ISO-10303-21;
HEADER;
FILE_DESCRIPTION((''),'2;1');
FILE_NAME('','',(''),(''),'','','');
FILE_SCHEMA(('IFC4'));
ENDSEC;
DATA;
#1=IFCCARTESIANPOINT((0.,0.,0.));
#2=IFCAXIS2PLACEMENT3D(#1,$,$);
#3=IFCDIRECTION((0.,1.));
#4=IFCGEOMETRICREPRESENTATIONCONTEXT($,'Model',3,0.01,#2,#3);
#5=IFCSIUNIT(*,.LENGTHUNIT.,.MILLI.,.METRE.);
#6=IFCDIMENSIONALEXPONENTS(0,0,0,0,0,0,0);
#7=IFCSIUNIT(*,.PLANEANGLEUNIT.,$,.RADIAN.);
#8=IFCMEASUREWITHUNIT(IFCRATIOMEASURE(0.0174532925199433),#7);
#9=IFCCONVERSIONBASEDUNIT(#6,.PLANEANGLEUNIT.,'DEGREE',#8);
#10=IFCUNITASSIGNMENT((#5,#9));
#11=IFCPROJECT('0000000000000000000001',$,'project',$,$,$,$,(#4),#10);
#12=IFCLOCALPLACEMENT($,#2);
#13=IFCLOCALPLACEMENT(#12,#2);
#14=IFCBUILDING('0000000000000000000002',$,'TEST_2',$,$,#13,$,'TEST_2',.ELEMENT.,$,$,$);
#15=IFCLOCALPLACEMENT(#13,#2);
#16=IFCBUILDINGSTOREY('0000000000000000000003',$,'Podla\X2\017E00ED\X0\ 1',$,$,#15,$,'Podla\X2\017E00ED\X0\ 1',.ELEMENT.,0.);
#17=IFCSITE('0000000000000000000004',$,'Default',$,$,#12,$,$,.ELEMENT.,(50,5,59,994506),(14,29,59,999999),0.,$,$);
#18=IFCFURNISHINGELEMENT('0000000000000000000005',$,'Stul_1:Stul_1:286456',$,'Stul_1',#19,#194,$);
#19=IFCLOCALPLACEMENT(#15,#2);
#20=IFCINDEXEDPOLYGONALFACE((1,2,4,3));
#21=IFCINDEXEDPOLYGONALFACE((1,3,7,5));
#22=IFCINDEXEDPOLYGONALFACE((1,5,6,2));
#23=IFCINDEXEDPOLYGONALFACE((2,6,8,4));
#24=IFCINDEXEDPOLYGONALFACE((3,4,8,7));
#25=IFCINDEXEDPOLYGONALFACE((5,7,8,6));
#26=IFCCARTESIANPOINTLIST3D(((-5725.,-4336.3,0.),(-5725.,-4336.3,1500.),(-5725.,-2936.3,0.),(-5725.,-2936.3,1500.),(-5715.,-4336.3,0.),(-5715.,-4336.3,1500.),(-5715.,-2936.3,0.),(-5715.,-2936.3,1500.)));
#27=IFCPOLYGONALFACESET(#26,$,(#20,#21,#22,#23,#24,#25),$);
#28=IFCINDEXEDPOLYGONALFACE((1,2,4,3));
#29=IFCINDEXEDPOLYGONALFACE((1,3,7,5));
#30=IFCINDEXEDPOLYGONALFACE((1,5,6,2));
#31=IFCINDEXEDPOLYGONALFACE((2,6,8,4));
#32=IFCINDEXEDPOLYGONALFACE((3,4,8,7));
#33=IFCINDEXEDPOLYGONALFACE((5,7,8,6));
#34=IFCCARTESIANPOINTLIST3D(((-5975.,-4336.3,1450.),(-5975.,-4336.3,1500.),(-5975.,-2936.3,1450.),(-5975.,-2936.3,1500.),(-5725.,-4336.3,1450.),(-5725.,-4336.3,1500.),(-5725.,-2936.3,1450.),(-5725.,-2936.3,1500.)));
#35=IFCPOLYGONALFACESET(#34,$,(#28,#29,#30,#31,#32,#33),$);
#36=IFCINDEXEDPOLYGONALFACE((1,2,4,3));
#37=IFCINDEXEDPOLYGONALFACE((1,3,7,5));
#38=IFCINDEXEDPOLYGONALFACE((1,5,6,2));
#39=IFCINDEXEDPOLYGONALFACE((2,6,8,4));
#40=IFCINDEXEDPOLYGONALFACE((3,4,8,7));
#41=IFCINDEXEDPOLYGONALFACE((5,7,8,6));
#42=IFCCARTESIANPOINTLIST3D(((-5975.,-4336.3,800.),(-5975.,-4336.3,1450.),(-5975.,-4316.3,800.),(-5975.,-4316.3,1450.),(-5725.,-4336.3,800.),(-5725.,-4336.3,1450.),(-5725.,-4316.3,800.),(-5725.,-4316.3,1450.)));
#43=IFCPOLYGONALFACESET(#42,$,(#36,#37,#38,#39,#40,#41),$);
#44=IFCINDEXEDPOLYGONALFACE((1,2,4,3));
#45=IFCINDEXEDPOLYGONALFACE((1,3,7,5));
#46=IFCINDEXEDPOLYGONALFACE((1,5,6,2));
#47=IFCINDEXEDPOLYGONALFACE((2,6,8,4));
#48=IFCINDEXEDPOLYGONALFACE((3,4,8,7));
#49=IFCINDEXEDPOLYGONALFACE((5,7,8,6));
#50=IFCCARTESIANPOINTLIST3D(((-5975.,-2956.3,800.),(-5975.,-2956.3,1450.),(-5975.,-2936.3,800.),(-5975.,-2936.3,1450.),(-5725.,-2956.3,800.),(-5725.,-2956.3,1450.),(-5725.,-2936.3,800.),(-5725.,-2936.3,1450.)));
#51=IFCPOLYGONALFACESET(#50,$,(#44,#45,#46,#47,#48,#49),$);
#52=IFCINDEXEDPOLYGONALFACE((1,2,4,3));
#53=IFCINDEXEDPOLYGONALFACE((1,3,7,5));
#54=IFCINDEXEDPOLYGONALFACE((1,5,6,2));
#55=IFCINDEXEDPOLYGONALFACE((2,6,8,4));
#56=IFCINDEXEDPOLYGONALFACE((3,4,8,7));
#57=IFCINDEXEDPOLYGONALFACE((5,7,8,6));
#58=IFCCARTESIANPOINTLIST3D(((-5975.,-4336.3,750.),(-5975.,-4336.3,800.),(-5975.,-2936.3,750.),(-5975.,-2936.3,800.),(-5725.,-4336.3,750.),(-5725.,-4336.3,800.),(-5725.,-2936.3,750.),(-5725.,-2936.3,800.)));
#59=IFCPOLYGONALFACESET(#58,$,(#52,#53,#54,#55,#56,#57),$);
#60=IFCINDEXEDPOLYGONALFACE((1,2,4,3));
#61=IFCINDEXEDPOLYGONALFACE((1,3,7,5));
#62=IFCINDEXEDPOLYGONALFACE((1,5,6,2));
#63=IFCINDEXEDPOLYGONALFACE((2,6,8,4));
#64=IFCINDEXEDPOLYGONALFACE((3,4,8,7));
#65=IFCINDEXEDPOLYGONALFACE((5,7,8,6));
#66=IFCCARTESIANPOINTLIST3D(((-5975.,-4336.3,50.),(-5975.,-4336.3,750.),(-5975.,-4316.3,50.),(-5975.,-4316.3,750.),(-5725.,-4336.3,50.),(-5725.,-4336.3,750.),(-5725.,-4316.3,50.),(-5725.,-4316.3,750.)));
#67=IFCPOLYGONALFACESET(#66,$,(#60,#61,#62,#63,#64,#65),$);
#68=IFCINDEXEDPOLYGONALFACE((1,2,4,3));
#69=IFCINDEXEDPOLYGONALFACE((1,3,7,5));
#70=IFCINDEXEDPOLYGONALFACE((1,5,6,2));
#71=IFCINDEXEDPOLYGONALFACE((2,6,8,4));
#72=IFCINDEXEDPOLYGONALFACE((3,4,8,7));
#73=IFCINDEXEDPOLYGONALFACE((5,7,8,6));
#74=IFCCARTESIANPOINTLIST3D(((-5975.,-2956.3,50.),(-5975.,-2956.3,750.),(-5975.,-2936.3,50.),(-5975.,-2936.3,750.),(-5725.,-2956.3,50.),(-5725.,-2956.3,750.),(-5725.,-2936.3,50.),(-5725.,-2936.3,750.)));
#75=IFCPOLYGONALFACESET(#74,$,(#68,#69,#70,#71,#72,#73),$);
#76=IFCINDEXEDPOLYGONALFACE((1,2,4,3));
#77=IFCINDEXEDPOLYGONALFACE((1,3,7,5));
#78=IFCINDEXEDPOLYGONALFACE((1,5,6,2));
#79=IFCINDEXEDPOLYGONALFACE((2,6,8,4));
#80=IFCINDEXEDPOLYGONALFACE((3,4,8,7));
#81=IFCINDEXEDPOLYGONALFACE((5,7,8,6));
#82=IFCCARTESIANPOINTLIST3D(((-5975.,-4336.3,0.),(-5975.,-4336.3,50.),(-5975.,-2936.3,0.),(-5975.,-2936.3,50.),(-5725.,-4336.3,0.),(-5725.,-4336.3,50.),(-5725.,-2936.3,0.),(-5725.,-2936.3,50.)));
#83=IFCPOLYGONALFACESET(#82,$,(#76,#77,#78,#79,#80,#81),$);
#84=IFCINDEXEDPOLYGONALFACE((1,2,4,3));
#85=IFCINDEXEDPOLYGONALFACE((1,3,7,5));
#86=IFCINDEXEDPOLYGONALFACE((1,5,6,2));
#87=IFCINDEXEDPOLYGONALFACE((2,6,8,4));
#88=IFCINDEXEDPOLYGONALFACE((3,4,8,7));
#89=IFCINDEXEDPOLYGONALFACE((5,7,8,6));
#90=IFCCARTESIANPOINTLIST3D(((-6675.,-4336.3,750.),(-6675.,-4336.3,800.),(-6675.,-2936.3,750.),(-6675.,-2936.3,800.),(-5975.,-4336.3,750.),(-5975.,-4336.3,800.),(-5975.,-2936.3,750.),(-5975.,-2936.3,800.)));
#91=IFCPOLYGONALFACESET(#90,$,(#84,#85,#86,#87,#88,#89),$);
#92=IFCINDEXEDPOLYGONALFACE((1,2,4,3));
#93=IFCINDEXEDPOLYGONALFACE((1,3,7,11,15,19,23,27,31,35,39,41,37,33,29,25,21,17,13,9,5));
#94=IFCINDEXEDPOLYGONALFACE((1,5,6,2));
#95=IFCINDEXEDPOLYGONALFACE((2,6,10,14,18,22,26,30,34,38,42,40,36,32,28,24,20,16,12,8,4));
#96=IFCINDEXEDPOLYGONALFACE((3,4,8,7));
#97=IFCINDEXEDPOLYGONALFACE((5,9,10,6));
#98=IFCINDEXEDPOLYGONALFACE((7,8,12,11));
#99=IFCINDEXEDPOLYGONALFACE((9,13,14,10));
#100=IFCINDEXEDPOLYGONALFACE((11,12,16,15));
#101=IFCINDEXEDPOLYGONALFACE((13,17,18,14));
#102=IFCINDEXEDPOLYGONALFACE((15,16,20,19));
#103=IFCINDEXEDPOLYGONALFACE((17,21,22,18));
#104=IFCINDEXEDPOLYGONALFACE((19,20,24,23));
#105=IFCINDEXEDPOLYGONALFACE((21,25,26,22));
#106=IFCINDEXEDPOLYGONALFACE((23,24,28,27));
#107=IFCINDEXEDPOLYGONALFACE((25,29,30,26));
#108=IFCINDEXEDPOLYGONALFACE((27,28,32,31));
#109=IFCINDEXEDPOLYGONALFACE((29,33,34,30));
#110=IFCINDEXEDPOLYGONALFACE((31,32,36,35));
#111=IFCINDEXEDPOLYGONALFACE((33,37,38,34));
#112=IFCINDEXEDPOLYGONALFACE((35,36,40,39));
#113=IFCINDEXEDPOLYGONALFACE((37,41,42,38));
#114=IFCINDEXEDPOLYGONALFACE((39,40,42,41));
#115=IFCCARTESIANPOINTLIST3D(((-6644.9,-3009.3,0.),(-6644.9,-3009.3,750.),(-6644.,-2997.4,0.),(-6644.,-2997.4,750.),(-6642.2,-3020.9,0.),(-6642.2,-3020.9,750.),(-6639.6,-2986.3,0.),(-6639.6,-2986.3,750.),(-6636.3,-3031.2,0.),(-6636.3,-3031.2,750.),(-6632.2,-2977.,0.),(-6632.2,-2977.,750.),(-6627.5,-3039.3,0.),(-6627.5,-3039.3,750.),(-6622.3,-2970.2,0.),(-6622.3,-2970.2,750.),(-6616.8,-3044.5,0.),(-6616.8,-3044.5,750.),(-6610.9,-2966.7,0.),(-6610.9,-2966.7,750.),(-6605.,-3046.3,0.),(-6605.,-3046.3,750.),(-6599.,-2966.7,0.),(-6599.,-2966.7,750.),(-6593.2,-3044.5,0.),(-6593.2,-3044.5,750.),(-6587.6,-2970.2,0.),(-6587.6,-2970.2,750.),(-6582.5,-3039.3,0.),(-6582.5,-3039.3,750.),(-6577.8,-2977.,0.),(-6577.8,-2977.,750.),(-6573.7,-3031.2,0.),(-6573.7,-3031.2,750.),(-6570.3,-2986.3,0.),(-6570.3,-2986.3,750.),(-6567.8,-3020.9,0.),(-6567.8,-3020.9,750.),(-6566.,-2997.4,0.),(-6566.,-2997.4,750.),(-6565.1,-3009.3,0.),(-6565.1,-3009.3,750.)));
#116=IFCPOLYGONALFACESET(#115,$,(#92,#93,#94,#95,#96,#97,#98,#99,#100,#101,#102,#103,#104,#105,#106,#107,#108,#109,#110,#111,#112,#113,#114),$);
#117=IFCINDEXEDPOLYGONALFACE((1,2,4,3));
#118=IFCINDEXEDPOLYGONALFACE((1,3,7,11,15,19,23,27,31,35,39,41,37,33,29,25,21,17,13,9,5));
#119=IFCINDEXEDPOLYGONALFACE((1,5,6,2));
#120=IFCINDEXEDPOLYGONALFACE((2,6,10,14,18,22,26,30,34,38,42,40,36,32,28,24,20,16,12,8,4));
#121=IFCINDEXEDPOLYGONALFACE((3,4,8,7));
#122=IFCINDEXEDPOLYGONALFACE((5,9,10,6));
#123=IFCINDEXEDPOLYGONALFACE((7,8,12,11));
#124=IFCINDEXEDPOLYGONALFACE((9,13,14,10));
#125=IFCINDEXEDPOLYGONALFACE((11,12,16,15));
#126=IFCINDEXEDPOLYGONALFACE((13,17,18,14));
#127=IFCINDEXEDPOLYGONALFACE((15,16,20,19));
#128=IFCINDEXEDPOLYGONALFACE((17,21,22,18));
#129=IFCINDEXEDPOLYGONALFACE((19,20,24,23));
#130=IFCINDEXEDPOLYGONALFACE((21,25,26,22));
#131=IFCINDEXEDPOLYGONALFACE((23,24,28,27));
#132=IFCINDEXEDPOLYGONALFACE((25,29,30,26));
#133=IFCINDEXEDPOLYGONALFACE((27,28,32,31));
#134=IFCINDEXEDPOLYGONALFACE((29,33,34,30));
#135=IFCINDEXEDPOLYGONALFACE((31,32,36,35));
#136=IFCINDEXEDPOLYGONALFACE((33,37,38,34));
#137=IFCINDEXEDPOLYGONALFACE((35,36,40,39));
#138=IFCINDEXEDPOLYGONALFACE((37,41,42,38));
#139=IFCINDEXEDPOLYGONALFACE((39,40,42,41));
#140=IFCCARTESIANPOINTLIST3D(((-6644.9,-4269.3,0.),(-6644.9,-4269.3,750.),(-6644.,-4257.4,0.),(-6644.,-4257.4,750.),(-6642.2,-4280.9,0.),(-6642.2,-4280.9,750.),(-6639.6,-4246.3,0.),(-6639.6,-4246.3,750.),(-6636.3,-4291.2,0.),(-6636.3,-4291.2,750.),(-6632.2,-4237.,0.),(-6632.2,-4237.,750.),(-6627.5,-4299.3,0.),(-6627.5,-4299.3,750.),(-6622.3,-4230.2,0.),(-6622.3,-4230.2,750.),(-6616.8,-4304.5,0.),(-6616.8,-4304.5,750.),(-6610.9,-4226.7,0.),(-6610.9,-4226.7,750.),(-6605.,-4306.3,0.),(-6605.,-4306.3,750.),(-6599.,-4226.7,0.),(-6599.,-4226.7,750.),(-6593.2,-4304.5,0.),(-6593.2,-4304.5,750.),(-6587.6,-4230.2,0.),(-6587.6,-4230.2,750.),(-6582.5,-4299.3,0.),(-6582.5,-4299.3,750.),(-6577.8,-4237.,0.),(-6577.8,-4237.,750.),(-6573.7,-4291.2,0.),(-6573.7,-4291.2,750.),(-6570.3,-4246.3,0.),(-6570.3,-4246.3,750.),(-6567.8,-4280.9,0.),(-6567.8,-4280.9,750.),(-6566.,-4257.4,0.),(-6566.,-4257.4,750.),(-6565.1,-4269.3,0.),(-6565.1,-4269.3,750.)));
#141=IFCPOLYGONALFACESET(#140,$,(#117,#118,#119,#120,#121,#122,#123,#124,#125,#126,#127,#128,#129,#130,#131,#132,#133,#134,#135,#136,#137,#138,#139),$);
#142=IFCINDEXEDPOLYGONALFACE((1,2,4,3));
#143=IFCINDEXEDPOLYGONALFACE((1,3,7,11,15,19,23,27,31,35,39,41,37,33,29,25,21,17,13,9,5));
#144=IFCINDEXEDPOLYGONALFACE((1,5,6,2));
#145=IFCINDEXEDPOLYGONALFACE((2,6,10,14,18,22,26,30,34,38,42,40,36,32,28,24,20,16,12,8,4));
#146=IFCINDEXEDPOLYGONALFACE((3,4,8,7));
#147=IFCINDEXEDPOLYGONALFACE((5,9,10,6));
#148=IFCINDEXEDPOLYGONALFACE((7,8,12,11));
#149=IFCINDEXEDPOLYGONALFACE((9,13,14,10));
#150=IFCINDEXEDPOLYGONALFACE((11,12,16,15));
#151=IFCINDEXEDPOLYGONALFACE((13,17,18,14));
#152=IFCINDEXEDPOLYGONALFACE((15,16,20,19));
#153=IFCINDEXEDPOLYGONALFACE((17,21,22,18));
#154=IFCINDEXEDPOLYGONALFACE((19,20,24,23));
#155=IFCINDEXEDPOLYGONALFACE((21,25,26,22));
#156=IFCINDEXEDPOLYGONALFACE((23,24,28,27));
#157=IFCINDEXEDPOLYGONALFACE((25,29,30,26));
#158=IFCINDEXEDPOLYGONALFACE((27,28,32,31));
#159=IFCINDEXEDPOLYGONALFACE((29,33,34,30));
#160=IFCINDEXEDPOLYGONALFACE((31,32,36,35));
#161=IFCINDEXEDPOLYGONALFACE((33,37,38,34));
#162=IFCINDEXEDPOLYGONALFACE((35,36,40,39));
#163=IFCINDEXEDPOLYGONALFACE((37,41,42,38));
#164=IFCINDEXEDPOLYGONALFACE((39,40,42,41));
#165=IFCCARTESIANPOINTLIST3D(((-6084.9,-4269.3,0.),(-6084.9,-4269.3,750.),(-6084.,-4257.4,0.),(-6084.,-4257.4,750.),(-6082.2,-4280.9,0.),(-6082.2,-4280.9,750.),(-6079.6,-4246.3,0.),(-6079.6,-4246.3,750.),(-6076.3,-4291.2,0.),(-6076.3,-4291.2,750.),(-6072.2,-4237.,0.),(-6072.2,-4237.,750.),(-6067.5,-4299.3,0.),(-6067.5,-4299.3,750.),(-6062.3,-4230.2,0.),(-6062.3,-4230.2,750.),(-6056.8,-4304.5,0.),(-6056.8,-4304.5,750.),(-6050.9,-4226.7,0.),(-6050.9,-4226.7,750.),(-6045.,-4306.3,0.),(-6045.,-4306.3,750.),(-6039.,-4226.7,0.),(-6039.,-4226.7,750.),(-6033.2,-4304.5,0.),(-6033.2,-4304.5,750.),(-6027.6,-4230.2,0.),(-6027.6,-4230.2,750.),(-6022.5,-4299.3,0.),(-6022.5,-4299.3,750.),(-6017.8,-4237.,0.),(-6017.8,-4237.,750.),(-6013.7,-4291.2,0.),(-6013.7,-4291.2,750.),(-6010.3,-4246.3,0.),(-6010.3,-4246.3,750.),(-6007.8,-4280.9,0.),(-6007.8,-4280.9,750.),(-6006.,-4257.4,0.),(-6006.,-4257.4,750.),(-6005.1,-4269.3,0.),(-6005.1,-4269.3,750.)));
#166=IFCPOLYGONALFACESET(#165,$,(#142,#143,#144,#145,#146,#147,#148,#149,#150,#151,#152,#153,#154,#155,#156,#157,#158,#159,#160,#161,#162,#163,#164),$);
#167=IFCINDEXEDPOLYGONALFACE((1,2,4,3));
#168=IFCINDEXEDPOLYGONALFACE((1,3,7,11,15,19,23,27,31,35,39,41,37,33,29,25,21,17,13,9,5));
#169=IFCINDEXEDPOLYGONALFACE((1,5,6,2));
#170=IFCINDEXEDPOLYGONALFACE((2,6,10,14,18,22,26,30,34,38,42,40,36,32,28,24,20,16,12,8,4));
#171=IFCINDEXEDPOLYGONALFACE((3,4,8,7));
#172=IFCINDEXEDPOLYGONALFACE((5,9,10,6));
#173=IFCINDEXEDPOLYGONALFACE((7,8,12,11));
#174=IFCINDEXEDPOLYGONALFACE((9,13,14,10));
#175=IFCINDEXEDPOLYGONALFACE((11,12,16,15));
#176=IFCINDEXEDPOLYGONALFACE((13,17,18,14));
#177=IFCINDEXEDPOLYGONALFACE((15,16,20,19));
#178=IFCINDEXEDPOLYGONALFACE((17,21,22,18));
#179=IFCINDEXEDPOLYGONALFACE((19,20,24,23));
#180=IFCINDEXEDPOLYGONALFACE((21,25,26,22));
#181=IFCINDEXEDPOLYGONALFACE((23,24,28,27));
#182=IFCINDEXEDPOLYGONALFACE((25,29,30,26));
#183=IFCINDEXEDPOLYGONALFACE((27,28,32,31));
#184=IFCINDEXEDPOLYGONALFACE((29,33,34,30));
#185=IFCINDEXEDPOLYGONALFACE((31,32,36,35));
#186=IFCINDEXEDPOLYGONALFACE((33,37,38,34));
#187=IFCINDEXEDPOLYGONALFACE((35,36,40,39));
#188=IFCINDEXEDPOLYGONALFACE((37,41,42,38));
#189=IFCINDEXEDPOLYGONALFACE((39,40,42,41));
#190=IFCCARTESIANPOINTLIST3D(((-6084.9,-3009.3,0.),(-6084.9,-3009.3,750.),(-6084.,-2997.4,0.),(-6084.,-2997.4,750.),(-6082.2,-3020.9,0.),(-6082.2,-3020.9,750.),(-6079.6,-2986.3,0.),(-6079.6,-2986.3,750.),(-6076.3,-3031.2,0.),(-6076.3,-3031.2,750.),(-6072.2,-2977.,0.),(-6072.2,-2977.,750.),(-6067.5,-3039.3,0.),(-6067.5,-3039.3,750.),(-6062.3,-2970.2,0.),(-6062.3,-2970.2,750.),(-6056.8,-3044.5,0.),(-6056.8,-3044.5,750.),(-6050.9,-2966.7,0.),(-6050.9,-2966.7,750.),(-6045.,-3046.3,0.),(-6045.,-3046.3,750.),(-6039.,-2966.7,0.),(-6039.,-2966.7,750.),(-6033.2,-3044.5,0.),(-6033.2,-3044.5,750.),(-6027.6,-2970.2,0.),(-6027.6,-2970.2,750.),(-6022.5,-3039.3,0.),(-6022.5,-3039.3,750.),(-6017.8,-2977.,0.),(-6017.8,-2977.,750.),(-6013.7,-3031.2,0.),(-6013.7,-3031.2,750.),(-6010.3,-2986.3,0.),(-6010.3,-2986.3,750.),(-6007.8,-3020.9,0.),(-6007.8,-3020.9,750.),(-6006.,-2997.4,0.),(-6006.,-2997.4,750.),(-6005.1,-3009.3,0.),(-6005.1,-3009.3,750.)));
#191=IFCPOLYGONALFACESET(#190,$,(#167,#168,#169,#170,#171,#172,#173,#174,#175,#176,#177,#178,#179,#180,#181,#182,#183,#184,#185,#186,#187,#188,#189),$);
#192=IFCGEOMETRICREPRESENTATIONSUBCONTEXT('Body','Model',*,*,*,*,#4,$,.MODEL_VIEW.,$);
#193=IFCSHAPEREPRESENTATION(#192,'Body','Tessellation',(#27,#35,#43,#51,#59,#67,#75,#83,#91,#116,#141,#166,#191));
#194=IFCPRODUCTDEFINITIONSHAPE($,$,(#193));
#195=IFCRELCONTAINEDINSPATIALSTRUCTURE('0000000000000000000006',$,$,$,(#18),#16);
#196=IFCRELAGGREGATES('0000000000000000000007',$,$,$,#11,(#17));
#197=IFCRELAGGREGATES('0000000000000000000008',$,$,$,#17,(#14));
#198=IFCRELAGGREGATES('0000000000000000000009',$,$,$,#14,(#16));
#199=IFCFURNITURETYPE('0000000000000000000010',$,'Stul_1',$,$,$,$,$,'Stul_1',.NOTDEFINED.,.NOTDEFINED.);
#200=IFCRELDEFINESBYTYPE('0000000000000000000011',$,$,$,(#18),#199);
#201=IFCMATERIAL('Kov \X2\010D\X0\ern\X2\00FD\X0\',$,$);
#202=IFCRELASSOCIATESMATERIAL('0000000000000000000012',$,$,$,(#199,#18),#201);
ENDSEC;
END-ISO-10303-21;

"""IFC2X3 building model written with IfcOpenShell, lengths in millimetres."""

from ifc_helpers import new_model, entity, si_unit, converted_unit, direction, frame, frame_2d, origin, origin_2d_with_axis, place, context, subcontext, project, spatial, rectangle, circle, extrude, source, transform, mapped, material, type_object, type_shapes, element, save


model = new_model("IFC2X3")

# Units and contexts
model_context = context("Model", 3, precision=0.01, world=origin(), true_north=direction((0.0, 1.0)))
body_context = subcontext(model_context, "Body", "Model", "MODEL_VIEW")
ifc_project = project(units=[si_unit("LENGTHUNIT", "METRE", prefix="MILLI"), converted_unit("PLANEANGLEUNIT", "DEGREE", entity("IfcRatioMeasure", 0.0174532925199433), si_unit("PLANEANGLEUNIT", "RADIAN"), dimensions=[0, 0, 0, 0, 0, 0, 0])], contexts=[model_context])

# Site, building, storey
site_placement = place(None, origin())
site = spatial("IfcSite", under=ifc_project, at=site_placement, Name="Default", CompositionType="ELEMENT", RefLatitude=(50, 5, 59, 994506), RefLongitude=(14, 29, 59, 999999), RefElevation=0.0)
building_placement = place(site_placement, origin())
building = spatial("IfcBuilding", under=site, at=building_placement, Name="TEST_2", LongName="TEST_2", CompositionType="ELEMENT")
storey_placement = place(building_placement, origin())
storey = spatial("IfcBuildingStorey", under=building, at=storey_placement, Name="Podlaží 1", LongName="Podlaží 1", CompositionType="ELEMENT", Elevation=0.0)

# Furnishing element
ifc_material_1 = material(Name="Kov černý")
furniture_type = type_object("IfcFurnitureType", Name="Stul_1", ElementType="Stul_1", material=ifc_material_1)
shared_shape_1 = source(origin(), body_context, "Body", "SweptSolid", [
    extrude(rectangle(XDim=1400.0, YDim=10.0, at=origin_2d_with_axis()), frame((0.0, 605.0, 0.0), z_axis=(0.0, 0.0, 1.0), x_axis=(-1.0, 0.0, 0.0)), (0.0, 0.0, 1.0), 1500.0),
    extrude(rectangle(XDim=1400.0, YDim=250.0, at=frame_2d((0.0, 0.0), x_axis=(1.0, 0.0))), frame((0.0, 475.0, 1450.0), z_axis=(0.0, 0.0, 1.0), x_axis=(-1.0, 0.0, 0.0)), (0.0, 0.0, 1.0), 50.0),
    extrude(rectangle(XDim=20.0, YDim=250.0, at=origin_2d_with_axis()), frame((690.0, 475.0, 800.0), z_axis=(0.0, 0.0, 1.0), x_axis=(-1.0, 0.0, 0.0)), (0.0, 0.0, 1.0), 650.0),
    extrude(rectangle(XDim=20.0, YDim=250.0, at=frame_2d((0.0, 0.0), x_axis=(1.0, 0.0))), frame((-690.0, 475.0, 800.0), z_axis=(0.0, 0.0, 1.0), x_axis=(-1.0, 0.0, 0.0)), (0.0, 0.0, 1.0), 650.0),
    extrude(rectangle(XDim=1400.0, YDim=250.0, at=origin_2d_with_axis()), frame((0.0, 475.0, 750.0), z_axis=(0.0, 0.0, 1.0), x_axis=(-1.0, 0.0, 0.0)), (0.0, 0.0, 1.0), 50.0),
    extrude(rectangle(XDim=20.0, YDim=250.0, at=origin_2d_with_axis()), frame((690.0, 475.0, 50.0), z_axis=(0.0, 0.0, 1.0), x_axis=(-1.0, 0.0, 0.0)), (0.0, 0.0, 1.0), 700.0),
    extrude(rectangle(XDim=20.0, YDim=250.0, at=frame_2d((0.0, 0.0), x_axis=(1.0, 0.0))), frame((-690.0, 475.0, 50.0), z_axis=(0.0, 0.0, 1.0), x_axis=(-1.0, 0.0, 0.0)), (0.0, 0.0, 1.0), 700.0),
    extrude(rectangle(XDim=1400.0, YDim=250.0, at=origin_2d_with_axis()), frame((0.0, 475.0, 0.0), z_axis=(0.0, 0.0, 1.0), x_axis=(-1.0, 0.0, 0.0)), (0.0, 0.0, 1.0), 50.0),
    extrude(rectangle(XDim=1400.0, YDim=700.0, at=origin_2d_with_axis()), frame((0.0, 0.0, 750.0), z_axis=(0.0, 0.0, 1.0), x_axis=(-1.0, 0.0, 0.0)), (0.0, 0.0, 1.0), 50.0),
    extrude(circle(Radius=40.0, at=frame_2d((0.0, 0.0), x_axis=(1.0, 0.0))), frame((-630.0, -280.0, 0.0)), (0.0, 0.0, 1.0), 750.0),
    extrude(circle(Radius=40.0, at=frame_2d((0.0, 0.0), x_axis=(1.0, 0.0))), frame((630.0, -280.0, 0.0)), (0.0, 0.0, 1.0), 750.0),
    extrude(circle(Radius=40.0, at=frame_2d((0.0, 0.0), x_axis=(1.0, 0.0))), frame((630.0, 280.0, 0.0)), (0.0, 0.0, 1.0), 750.0),
    extrude(circle(Radius=40.0, at=frame_2d((0.0, 0.0), x_axis=(1.0, 0.0))), frame((-630.0, 280.0, 0.0)), (0.0, 0.0, 1.0), 750.0),
])
type_shapes(furniture_type, [shared_shape_1])
for number, where, z_axis, x_axis, name in (
    (1, (-6325.0, -3636.3, 0.0), (0.0, 0.0, 1.0), (0.0, -1.0, 0.0), "Stul_1:Stul_1:286456"),
):
    element("IfcFurnishingElement", number, at=place(storey_placement, frame(where, z_axis=z_axis, x_axis=x_axis)), inside=storey, type_object=furniture_type, material=ifc_material_1, Name=name, ObjectType="Stul_1", context=body_context, shape_type="MappedRepresentation", body=[
        mapped(shared_shape_1, transform((0.0, 0.0, 0.0), scale=1.0)),
    ])

save(model, "model.ifc")
